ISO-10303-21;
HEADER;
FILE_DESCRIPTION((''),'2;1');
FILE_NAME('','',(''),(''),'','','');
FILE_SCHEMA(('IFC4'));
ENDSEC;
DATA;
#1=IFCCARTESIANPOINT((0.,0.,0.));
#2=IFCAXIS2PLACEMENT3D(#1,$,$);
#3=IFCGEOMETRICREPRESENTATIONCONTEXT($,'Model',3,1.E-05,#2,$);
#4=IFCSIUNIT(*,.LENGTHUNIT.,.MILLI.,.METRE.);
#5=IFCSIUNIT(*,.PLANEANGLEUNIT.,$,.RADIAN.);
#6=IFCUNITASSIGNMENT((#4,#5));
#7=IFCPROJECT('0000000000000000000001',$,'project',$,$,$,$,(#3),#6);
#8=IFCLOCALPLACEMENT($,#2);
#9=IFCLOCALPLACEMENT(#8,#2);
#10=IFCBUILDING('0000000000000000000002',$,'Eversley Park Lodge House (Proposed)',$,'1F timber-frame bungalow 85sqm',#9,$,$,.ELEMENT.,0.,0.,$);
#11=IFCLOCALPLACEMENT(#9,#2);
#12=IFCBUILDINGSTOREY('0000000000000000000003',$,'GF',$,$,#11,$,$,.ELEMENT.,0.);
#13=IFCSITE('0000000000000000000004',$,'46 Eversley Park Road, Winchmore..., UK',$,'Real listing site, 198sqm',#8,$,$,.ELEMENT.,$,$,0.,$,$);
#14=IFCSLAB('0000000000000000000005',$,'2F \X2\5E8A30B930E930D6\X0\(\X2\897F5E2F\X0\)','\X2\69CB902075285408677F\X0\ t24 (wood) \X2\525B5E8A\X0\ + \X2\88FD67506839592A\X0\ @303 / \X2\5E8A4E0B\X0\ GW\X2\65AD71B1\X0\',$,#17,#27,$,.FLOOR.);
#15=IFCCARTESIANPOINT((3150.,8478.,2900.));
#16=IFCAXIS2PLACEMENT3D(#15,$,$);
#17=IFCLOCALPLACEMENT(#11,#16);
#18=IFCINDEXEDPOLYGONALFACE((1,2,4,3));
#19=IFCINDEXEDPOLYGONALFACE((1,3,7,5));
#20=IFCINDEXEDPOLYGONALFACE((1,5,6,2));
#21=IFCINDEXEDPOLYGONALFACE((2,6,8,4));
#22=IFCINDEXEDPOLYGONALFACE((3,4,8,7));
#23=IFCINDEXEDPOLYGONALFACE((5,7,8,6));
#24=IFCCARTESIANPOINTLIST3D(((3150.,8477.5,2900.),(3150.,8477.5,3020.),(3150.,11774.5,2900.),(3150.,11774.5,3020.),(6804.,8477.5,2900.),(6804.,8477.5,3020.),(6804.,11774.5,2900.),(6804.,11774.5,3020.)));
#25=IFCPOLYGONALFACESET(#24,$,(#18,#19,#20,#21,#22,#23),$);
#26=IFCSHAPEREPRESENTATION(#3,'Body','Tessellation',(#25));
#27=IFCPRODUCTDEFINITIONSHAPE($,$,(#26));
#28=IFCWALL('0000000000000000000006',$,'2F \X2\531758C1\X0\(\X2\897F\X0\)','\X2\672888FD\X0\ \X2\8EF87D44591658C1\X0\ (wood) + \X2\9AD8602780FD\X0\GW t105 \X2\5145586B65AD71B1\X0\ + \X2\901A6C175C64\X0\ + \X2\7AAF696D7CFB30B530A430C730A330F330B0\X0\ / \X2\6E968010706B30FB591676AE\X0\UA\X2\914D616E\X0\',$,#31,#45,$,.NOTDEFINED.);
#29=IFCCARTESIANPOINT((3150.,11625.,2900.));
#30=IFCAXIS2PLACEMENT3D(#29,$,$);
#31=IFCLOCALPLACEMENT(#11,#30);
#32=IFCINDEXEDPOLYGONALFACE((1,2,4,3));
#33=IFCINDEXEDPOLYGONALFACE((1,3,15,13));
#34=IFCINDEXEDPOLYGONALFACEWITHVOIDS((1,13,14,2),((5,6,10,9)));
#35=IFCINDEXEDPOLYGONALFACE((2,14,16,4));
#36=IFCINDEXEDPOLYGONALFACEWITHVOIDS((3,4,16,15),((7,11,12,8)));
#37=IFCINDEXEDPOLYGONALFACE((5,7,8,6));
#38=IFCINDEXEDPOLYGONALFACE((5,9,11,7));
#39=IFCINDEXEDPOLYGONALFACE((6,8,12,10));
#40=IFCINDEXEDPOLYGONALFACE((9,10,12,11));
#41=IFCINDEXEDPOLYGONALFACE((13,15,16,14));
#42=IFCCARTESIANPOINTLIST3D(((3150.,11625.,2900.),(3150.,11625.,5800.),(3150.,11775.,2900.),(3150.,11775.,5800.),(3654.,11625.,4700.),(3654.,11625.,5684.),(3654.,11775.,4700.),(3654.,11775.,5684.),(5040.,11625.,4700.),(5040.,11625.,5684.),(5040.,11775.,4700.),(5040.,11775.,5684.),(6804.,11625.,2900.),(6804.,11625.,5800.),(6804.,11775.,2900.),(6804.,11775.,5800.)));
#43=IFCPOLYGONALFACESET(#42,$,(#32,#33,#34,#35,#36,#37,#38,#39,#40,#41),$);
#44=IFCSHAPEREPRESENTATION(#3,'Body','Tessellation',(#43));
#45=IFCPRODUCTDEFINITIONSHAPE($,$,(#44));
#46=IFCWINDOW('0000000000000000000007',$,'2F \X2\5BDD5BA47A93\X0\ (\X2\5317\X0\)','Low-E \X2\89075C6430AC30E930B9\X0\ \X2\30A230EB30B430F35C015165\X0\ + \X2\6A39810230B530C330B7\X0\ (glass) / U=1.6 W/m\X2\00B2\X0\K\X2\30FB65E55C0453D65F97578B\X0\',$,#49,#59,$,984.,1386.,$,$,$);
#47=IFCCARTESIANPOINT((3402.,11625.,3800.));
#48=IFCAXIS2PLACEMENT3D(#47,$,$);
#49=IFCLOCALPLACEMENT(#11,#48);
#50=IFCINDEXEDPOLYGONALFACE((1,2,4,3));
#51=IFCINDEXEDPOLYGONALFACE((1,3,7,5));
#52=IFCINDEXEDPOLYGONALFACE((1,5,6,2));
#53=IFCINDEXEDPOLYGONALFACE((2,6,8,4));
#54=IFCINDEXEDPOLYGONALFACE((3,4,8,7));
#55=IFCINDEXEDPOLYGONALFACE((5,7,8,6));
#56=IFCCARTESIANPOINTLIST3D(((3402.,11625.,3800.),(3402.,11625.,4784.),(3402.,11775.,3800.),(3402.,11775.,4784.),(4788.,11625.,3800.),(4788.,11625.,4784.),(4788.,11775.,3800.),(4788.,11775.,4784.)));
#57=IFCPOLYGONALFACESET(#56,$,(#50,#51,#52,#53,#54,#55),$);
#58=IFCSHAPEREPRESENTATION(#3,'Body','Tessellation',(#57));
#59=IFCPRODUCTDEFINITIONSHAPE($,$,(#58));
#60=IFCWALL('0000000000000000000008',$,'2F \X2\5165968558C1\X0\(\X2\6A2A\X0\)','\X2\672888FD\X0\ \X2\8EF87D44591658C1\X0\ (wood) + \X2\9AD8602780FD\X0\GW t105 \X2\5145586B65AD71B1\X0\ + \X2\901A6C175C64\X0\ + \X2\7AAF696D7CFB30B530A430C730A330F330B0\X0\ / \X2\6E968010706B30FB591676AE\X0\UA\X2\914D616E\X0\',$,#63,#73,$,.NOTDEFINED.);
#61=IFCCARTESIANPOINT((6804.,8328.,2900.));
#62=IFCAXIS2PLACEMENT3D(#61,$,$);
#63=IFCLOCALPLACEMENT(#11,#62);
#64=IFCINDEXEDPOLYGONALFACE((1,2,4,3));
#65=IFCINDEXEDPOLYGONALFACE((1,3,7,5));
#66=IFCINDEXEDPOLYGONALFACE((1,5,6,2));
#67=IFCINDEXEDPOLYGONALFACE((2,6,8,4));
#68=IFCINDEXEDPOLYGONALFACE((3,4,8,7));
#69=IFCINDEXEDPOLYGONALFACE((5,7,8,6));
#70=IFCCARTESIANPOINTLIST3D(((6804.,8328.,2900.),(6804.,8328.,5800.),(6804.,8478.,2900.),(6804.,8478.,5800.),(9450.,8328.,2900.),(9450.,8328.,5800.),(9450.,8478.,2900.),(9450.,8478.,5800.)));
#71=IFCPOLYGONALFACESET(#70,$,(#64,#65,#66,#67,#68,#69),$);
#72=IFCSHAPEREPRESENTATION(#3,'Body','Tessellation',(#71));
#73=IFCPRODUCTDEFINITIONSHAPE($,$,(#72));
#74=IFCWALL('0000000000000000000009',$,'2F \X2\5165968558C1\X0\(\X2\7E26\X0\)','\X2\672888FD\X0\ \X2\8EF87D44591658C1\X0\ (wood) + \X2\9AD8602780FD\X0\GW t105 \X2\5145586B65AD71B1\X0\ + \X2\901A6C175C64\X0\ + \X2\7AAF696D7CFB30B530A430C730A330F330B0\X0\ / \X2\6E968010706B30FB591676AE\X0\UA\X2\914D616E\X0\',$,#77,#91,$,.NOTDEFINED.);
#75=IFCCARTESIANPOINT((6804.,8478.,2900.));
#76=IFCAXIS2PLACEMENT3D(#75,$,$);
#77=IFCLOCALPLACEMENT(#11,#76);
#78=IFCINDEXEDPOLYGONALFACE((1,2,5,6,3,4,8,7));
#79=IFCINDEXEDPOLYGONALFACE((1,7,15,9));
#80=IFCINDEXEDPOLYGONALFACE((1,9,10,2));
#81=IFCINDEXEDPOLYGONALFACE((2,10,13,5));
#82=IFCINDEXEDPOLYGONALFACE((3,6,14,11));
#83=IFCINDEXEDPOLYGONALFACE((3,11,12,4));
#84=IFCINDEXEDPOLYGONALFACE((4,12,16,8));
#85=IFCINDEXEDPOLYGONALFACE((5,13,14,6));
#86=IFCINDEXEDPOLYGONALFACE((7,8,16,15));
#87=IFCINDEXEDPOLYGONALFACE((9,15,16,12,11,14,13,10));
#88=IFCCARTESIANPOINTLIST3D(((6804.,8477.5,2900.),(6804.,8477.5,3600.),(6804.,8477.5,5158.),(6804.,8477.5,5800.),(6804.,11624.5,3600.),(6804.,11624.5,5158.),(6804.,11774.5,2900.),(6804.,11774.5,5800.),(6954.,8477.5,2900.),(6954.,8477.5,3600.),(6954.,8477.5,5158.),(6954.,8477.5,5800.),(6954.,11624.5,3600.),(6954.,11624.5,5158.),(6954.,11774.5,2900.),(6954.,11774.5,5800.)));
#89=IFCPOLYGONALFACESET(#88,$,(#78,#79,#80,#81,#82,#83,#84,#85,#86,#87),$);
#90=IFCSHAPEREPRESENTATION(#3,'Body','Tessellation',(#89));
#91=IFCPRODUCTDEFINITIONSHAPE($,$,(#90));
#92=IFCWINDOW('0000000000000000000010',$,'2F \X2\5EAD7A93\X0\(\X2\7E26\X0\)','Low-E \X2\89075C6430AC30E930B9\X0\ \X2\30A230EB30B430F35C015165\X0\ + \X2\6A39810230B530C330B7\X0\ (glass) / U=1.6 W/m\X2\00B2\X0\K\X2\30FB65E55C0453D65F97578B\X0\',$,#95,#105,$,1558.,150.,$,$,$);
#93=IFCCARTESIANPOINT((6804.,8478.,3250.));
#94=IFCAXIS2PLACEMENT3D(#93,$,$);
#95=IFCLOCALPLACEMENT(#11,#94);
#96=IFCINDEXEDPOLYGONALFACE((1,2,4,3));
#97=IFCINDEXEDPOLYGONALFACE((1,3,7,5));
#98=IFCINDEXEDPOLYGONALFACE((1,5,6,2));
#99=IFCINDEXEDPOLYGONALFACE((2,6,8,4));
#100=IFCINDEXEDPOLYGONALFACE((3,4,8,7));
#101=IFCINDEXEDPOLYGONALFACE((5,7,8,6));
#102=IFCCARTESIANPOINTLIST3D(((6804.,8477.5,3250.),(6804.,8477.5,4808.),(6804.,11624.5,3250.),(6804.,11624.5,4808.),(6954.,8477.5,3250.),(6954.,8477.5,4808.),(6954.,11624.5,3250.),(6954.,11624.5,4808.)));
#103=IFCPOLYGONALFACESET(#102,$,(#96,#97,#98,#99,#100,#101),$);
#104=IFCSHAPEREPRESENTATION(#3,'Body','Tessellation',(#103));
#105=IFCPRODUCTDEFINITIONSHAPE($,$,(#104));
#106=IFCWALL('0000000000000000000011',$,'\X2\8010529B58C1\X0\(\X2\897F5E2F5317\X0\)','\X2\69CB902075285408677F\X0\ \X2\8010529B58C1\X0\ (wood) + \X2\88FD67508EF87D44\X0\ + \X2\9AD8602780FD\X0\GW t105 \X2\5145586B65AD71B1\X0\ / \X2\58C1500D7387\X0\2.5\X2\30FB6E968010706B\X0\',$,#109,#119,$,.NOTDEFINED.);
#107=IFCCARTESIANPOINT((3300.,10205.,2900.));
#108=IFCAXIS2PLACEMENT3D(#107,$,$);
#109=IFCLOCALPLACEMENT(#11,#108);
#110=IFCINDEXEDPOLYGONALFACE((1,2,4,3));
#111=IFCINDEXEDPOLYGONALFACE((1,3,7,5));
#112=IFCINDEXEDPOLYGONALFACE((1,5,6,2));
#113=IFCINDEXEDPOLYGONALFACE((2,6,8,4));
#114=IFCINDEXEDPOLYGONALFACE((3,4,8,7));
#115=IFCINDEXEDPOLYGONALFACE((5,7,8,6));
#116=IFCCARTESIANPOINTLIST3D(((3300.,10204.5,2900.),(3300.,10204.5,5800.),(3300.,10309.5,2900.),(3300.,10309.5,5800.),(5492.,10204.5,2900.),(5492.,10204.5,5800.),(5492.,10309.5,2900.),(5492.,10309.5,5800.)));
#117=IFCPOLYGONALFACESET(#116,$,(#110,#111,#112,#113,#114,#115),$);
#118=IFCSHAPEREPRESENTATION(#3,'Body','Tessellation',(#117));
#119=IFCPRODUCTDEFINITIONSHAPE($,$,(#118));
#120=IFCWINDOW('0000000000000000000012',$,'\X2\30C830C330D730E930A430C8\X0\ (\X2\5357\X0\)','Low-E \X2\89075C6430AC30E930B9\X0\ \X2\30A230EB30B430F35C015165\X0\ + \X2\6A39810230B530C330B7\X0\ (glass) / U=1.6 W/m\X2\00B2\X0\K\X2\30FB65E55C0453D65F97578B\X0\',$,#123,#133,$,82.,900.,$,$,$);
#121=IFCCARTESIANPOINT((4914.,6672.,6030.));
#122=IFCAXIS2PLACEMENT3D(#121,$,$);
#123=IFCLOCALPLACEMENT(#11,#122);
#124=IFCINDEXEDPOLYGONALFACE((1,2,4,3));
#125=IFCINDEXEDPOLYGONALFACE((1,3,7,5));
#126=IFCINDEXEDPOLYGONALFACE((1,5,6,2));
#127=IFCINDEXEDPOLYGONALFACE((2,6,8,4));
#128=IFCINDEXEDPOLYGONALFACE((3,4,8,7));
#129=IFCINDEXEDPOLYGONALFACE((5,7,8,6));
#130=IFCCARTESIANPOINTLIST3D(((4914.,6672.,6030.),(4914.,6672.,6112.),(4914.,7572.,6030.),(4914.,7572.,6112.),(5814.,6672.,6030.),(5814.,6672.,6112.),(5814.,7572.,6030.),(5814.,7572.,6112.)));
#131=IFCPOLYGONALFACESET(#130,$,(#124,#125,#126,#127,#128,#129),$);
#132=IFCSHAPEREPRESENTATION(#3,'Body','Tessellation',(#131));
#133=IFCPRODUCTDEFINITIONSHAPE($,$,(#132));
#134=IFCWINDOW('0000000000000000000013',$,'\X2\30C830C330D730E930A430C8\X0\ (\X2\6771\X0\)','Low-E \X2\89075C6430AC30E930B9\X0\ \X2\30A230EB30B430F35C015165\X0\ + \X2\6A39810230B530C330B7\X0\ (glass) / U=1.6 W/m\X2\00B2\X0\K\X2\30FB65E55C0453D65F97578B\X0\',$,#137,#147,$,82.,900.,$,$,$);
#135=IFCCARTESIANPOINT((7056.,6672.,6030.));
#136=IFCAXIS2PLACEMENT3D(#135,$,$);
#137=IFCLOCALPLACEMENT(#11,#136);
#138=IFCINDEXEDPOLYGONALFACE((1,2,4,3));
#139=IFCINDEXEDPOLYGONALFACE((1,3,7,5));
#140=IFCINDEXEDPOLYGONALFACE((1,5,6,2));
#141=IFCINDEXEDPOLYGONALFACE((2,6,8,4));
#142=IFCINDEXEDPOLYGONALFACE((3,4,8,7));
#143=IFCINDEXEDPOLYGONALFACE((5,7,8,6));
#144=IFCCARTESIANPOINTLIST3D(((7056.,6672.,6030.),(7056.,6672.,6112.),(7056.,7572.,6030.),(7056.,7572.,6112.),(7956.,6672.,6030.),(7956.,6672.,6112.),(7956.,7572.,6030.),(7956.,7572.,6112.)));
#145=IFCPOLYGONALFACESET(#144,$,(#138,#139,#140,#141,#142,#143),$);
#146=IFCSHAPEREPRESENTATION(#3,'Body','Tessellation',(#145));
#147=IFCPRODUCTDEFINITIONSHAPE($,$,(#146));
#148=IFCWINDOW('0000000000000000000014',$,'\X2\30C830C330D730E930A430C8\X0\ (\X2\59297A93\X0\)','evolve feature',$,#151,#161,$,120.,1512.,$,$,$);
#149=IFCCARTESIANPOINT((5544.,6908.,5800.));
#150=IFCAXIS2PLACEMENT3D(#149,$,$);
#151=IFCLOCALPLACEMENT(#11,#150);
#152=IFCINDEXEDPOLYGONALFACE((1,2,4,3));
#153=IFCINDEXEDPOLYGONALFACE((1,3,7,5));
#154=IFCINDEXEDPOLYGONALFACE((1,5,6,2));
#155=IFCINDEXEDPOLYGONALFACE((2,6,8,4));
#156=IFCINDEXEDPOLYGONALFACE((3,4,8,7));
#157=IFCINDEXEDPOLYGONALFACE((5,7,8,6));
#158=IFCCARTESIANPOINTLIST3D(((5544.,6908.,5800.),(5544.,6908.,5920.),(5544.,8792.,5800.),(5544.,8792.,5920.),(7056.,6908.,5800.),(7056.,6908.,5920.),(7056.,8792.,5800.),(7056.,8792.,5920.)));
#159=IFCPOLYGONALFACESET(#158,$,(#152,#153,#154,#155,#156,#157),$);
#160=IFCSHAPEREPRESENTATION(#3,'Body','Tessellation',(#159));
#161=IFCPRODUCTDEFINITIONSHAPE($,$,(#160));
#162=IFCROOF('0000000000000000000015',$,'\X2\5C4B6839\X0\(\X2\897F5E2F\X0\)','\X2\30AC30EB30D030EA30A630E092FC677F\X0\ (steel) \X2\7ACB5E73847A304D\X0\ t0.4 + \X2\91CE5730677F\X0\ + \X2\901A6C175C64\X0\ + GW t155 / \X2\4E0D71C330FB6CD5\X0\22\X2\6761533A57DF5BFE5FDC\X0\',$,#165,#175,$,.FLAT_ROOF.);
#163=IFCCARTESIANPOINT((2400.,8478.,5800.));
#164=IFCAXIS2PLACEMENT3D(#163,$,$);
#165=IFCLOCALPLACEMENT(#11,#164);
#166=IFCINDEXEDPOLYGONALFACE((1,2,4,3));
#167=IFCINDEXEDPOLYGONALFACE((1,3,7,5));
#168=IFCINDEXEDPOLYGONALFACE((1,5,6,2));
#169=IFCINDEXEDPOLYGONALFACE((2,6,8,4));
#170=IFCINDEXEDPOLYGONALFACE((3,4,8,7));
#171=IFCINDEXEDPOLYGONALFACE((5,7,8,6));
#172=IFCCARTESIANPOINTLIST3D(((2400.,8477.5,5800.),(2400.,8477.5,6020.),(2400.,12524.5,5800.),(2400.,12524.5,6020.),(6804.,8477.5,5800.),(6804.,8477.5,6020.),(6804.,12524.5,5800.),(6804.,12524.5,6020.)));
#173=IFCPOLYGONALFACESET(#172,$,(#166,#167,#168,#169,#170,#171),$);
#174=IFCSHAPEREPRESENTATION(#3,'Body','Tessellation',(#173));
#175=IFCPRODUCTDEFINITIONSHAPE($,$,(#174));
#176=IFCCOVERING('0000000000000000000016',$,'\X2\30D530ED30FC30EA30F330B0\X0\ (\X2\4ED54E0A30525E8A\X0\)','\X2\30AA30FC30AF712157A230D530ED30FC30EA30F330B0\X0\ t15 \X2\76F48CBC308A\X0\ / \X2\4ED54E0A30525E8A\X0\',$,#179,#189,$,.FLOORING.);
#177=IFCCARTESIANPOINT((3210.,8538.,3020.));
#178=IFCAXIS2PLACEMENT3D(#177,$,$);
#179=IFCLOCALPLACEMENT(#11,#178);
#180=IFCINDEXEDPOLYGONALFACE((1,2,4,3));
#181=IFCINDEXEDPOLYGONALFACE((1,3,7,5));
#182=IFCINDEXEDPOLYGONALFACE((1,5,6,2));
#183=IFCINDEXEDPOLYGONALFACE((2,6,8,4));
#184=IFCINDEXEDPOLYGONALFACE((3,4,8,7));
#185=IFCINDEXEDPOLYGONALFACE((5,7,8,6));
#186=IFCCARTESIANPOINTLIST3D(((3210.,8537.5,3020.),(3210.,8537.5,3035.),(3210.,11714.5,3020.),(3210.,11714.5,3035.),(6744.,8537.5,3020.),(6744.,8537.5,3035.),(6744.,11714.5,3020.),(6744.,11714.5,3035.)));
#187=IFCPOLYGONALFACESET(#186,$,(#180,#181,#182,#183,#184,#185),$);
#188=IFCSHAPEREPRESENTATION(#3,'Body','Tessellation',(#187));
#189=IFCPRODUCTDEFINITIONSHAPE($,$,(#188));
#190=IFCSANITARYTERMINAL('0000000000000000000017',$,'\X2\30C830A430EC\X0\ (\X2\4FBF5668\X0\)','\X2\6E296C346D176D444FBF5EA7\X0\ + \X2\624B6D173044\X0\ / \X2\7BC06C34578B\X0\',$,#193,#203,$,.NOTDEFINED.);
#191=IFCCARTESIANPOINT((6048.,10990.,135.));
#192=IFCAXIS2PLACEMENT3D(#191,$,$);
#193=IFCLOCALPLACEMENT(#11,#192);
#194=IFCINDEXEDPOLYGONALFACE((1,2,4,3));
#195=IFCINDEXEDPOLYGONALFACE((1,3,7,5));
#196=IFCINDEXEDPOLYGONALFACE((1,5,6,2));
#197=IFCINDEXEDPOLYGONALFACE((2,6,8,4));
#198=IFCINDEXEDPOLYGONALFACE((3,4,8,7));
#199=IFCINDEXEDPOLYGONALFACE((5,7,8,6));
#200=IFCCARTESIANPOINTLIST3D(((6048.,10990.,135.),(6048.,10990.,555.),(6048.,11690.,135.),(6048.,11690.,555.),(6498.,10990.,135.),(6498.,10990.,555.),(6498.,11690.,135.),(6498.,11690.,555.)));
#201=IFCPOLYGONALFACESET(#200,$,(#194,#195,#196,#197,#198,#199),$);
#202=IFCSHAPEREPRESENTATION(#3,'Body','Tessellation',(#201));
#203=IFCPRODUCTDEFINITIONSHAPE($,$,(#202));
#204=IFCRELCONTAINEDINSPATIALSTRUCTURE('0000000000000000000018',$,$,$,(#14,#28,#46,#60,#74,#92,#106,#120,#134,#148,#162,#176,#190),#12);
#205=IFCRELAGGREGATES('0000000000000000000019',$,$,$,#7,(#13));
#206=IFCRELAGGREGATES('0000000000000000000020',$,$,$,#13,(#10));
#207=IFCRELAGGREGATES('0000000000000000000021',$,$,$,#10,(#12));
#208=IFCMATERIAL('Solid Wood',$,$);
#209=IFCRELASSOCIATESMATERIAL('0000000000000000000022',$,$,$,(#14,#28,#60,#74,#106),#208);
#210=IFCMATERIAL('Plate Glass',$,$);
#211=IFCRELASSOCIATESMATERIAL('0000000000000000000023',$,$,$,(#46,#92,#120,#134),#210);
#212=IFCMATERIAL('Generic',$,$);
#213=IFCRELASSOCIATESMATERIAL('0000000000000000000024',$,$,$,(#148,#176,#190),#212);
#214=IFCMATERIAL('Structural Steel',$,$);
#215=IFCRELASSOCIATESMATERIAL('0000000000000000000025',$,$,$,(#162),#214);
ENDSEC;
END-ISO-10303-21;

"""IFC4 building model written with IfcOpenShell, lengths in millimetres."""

from ifc_helpers import new_model, si_unit, frame, frame_2d, origin, place, context, project, spatial, rectangle, extrude, material, element, fill, save


model = new_model("IFC4")

# Units and contexts
model_context = context("Model", 3, precision=1e-05, world=origin())
ifc_project = project(units=[si_unit("LENGTHUNIT", "METRE", prefix="MILLI"), si_unit("PLANEANGLEUNIT", "RADIAN")], contexts=[model_context])

# Site, building, storey
site_placement = place(None, origin())
site = spatial("IfcSite", under=ifc_project, at=site_placement, Name="46 Eversley Park Road, Winchmore..., UK", ObjectType="Real listing site, 198sqm", CompositionType="ELEMENT", RefElevation=0.0)
building_placement = place(site_placement, origin())
building = spatial("IfcBuilding", under=site, at=building_placement, Name="Eversley Park Lodge House (Proposed)", ObjectType="1F timber-frame bungalow 85sqm", CompositionType="ELEMENT", ElevationOfRefHeight=0.0, ElevationOfTerrain=0.0)
storey_placement = place(building_placement, origin())
storey = spatial("IfcBuildingStorey", under=building, at=storey_placement, Name="GF", CompositionType="ELEMENT", Elevation=0.0)

# Slab
ifc_material_1 = material(Name="Solid Wood")
slab_placement = place(storey_placement, frame((3150.0, 8478.0, 2900.0)))
element("IfcSlab", 1, at=slab_placement, inside=storey, material=ifc_material_1, Name="2F 床スラブ(西帯)", Description="構造用合板 t24 (wood) 剛床 + 製材根太 @303 / 床下 GW断熱", PredefinedType="FLOOR", context=model_context, shape_type="SweptSolid", body=[
    extrude(rectangle(XDim=3654.0, YDim=3297.0, at=frame_2d((1827.0, 1648.0))), frame((3150.0, 8478.0, 2900.0)), (0.0, 0.0, 1.0), 120.0),
])

# Wall, opening, window
wall_1_placement = place(storey_placement, frame((3150.0, 11625.0, 2900.0)))
wall_1 = element("IfcWall", 2, at=wall_1_placement, inside=storey, material=ifc_material_1, Name="2F 北壁(西)", Description="木製 軸組外壁 (wood) + 高性能GW t105 充填断熱 + 通気層 + 窯業系サイディング / 準耐火・外皮UA配慮", PredefinedType="NOTDEFINED", context=model_context, shape_type="SweptSolid", body=[
    extrude(rectangle(XDim=3654.0, YDim=150.0, at=frame_2d((1827.0, 75.0))), frame((3150.0, 11625.0, 2900.0)), (0.0, 0.0, 1.0), 2900.0),
])
opening_1_placement = place(storey_placement, frame((3402.0, 11625.0, 3800.0)))
opening_1 = element("IfcOpeningElement", 3, at=opening_1_placement, cuts=wall_1, PredefinedType="NOTDEFINED", context=model_context, shape_type="SweptSolid", body=[
    extrude(rectangle(XDim=1386.0, YDim=150.0, at=frame_2d((693.0, 75.0))), frame((3402.0, 11625.0, 3800.0)), (0.0, 0.0, 1.0), 984.0),
])
ifc_material_2 = material(Name="Plate Glass")
window_1_placement = place(storey_placement, frame((3402.0, 11625.0, 3800.0)))
window_1 = element("IfcWindow", 4, at=window_1_placement, inside=storey, material=ifc_material_2, Name="2F 寝室窓 (北)", Description="Low-E 複層ガラス アルゴン封入 + 樹脂サッシ (glass) / U=1.6 W/m²K・日射取得型", OverallHeight=984.0, OverallWidth=1386.0, context=model_context, shape_type="SweptSolid", body=[
    extrude(rectangle(XDim=1386.0, YDim=150.0, at=frame_2d((693.0, 75.0))), frame((3402.0, 11625.0, 3800.0)), (0.0, 0.0, 1.0), 984.0),
])
fill(opening_1, window_1)

# Wall
wall_2_placement = place(storey_placement, frame((6804.0, 8328.0, 2900.0)))
element("IfcWall", 5, at=wall_2_placement, inside=storey, material=ifc_material_1, Name="2F 入隅壁(横)", Description="木製 軸組外壁 (wood) + 高性能GW t105 充填断熱 + 通気層 + 窯業系サイディング / 準耐火・外皮UA配慮", PredefinedType="NOTDEFINED", context=model_context, shape_type="SweptSolid", body=[
    extrude(rectangle(XDim=2646.0, YDim=150.0, at=frame_2d((1323.0, 75.0))), frame((6804.0, 8328.0, 2900.0)), (0.0, 0.0, 1.0), 2900.0),
])

# Wall, opening, window
wall_3_placement = place(storey_placement, frame((6804.0, 8478.0, 2900.0)))
wall_3 = element("IfcWall", 6, at=wall_3_placement, inside=storey, material=ifc_material_1, Name="2F 入隅壁(縦)", Description="木製 軸組外壁 (wood) + 高性能GW t105 充填断熱 + 通気層 + 窯業系サイディング / 準耐火・外皮UA配慮", PredefinedType="NOTDEFINED", context=model_context, shape_type="SweptSolid", body=[
    extrude(rectangle(XDim=150.0, YDim=3297.0, at=frame_2d((75.0, 1648.0))), frame((6804.0, 8478.0, 2900.0)), (0.0, 0.0, 1.0), 2900.0),
])
opening_2_placement = place(storey_placement, frame((6804.0, 8478.0, 3250.0)))
opening_2 = element("IfcOpeningElement", 7, at=opening_2_placement, cuts=wall_3, PredefinedType="NOTDEFINED", context=model_context, shape_type="SweptSolid", body=[
    extrude(rectangle(XDim=150.0, YDim=3147.0, at=frame_2d((75.0, 1573.0))), frame((6804.0, 8478.0, 3250.0)), (0.0, 0.0, 1.0), 1558.0),
])
window_2_placement = place(storey_placement, frame((6804.0, 8478.0, 3250.0)))
window_2 = element("IfcWindow", 8, at=window_2_placement, inside=storey, material=ifc_material_2, Name="2F 庭窓(縦)", Description="Low-E 複層ガラス アルゴン封入 + 樹脂サッシ (glass) / U=1.6 W/m²K・日射取得型", OverallHeight=1558.0, OverallWidth=150.0, context=model_context, shape_type="SweptSolid", body=[
    extrude(rectangle(XDim=150.0, YDim=3147.0, at=frame_2d((75.0, 1573.0))), frame((6804.0, 8478.0, 3250.0)), (0.0, 0.0, 1.0), 1558.0),
])
fill(opening_2, window_2)

# Wall
wall_4_placement = place(storey_placement, frame((3300.0, 10205.0, 2900.0)))
element("IfcWall", 9, at=wall_4_placement, inside=storey, material=ifc_material_1, Name="耐力壁(西帯北)", Description="構造用合板 耐力壁 (wood) + 製材軸組 + 高性能GW t105 充填断熱 / 壁倍率2.5・準耐火", PredefinedType="NOTDEFINED", context=model_context, shape_type="SweptSolid", body=[
    extrude(rectangle(XDim=2192.0, YDim=105.0, at=frame_2d((1096.0, 52.0))), frame((3300.0, 10205.0, 2900.0)), (0.0, 0.0, 1.0), 2900.0),
])

# Windows
window_3_placement = place(storey_placement, frame((4914.0, 6672.0, 6030.0)))
element("IfcWindow", 10, at=window_3_placement, inside=storey, material=ifc_material_2, Name="トップライト (南)", Description="Low-E 複層ガラス アルゴン封入 + 樹脂サッシ (glass) / U=1.6 W/m²K・日射取得型", OverallHeight=82.0, OverallWidth=900.0, context=model_context, shape_type="SweptSolid", body=[
    extrude(rectangle(XDim=900.0, YDim=900.0, at=frame_2d((450.0, 450.0))), frame((4914.0, 6672.0, 6030.0)), (0.0, 0.0, 1.0), 82.0),
])
window_4_placement = place(storey_placement, frame((7056.0, 6672.0, 6030.0)))
element("IfcWindow", 11, at=window_4_placement, inside=storey, material=ifc_material_2, Name="トップライト (東)", Description="Low-E 複層ガラス アルゴン封入 + 樹脂サッシ (glass) / U=1.6 W/m²K・日射取得型", OverallHeight=82.0, OverallWidth=900.0, context=model_context, shape_type="SweptSolid", body=[
    extrude(rectangle(XDim=900.0, YDim=900.0, at=frame_2d((450.0, 450.0))), frame((7056.0, 6672.0, 6030.0)), (0.0, 0.0, 1.0), 82.0),
])
ifc_material_3 = material(Name="Generic")
window_5_placement = place(storey_placement, frame((5544.0, 6908.0, 5800.0)))
element("IfcWindow", 12, at=window_5_placement, inside=storey, material=ifc_material_3, Name="トップライト (天窓)", Description="evolve feature", OverallHeight=120.0, OverallWidth=1512.0, context=model_context, shape_type="SweptSolid", body=[
    extrude(rectangle(XDim=1512.0, YDim=1884.0, at=frame_2d((756.0, 942.0))), frame((5544.0, 6908.0, 5800.0)), (0.0, 0.0, 1.0), 120.0),
])

# Roof
ifc_material_4 = material(Name="Structural Steel")
for number, where, name in (
    (13, (2400.0, 8478.0, 5800.0), "屋根(西帯)"),
):
    element("IfcRoof", number, at=place(storey_placement, frame(where)), inside=storey, material=ifc_material_4, Name=name, Description="ガルバリウム鋼板 (steel) 立平葺き t0.4 + 野地板 + 通気層 + GW t155 / 不燃・法22条区域対応", PredefinedType="FLAT_ROOF", context=model_context, shape_type="SweptSolid", body=[
        extrude(rectangle(XDim=4404.0, YDim=4047.0, at=frame_2d((2202.0, 2023.0))), frame((2400.0, 8478.0, 5800.0)), (0.0, 0.0, 1.0), 220.0),
    ])

# Covering
covering_placement = place(storey_placement, frame((3210.0, 8538.0, 3020.0)))
element("IfcCovering", 14, at=covering_placement, inside=storey, material=ifc_material_3, Name="フローリング (仕上げ床)", Description="オーク無垢フローリング t15 直貼り / 仕上げ床", PredefinedType="FLOORING", context=model_context, shape_type="SweptSolid", body=[
    extrude(rectangle(XDim=3534.0, YDim=3177.0, at=frame_2d((1767.0, 1588.0))), frame((3210.0, 8538.0, 3020.0)), (0.0, 0.0, 1.0), 15.0),
])

# Sanitary terminal
sanitary_terminal_placement = place(storey_placement, frame((6048.0, 10990.0, 135.0)))
element("IfcSanitaryTerminal", 15, at=sanitary_terminal_placement, inside=storey, material=ifc_material_3, Name="トイレ (便器)", Description="温水洗浄便座 + 手洗い / 節水型", PredefinedType="NOTDEFINED", context=model_context, shape_type="SweptSolid", body=[
    extrude(rectangle(XDim=450.0, YDim=700.0, at=frame_2d((225.0, 350.0))), frame((6048.0, 10990.0, 135.0)), (0.0, 0.0, 1.0), 420.0),
])

save(model, "model.ifc")
